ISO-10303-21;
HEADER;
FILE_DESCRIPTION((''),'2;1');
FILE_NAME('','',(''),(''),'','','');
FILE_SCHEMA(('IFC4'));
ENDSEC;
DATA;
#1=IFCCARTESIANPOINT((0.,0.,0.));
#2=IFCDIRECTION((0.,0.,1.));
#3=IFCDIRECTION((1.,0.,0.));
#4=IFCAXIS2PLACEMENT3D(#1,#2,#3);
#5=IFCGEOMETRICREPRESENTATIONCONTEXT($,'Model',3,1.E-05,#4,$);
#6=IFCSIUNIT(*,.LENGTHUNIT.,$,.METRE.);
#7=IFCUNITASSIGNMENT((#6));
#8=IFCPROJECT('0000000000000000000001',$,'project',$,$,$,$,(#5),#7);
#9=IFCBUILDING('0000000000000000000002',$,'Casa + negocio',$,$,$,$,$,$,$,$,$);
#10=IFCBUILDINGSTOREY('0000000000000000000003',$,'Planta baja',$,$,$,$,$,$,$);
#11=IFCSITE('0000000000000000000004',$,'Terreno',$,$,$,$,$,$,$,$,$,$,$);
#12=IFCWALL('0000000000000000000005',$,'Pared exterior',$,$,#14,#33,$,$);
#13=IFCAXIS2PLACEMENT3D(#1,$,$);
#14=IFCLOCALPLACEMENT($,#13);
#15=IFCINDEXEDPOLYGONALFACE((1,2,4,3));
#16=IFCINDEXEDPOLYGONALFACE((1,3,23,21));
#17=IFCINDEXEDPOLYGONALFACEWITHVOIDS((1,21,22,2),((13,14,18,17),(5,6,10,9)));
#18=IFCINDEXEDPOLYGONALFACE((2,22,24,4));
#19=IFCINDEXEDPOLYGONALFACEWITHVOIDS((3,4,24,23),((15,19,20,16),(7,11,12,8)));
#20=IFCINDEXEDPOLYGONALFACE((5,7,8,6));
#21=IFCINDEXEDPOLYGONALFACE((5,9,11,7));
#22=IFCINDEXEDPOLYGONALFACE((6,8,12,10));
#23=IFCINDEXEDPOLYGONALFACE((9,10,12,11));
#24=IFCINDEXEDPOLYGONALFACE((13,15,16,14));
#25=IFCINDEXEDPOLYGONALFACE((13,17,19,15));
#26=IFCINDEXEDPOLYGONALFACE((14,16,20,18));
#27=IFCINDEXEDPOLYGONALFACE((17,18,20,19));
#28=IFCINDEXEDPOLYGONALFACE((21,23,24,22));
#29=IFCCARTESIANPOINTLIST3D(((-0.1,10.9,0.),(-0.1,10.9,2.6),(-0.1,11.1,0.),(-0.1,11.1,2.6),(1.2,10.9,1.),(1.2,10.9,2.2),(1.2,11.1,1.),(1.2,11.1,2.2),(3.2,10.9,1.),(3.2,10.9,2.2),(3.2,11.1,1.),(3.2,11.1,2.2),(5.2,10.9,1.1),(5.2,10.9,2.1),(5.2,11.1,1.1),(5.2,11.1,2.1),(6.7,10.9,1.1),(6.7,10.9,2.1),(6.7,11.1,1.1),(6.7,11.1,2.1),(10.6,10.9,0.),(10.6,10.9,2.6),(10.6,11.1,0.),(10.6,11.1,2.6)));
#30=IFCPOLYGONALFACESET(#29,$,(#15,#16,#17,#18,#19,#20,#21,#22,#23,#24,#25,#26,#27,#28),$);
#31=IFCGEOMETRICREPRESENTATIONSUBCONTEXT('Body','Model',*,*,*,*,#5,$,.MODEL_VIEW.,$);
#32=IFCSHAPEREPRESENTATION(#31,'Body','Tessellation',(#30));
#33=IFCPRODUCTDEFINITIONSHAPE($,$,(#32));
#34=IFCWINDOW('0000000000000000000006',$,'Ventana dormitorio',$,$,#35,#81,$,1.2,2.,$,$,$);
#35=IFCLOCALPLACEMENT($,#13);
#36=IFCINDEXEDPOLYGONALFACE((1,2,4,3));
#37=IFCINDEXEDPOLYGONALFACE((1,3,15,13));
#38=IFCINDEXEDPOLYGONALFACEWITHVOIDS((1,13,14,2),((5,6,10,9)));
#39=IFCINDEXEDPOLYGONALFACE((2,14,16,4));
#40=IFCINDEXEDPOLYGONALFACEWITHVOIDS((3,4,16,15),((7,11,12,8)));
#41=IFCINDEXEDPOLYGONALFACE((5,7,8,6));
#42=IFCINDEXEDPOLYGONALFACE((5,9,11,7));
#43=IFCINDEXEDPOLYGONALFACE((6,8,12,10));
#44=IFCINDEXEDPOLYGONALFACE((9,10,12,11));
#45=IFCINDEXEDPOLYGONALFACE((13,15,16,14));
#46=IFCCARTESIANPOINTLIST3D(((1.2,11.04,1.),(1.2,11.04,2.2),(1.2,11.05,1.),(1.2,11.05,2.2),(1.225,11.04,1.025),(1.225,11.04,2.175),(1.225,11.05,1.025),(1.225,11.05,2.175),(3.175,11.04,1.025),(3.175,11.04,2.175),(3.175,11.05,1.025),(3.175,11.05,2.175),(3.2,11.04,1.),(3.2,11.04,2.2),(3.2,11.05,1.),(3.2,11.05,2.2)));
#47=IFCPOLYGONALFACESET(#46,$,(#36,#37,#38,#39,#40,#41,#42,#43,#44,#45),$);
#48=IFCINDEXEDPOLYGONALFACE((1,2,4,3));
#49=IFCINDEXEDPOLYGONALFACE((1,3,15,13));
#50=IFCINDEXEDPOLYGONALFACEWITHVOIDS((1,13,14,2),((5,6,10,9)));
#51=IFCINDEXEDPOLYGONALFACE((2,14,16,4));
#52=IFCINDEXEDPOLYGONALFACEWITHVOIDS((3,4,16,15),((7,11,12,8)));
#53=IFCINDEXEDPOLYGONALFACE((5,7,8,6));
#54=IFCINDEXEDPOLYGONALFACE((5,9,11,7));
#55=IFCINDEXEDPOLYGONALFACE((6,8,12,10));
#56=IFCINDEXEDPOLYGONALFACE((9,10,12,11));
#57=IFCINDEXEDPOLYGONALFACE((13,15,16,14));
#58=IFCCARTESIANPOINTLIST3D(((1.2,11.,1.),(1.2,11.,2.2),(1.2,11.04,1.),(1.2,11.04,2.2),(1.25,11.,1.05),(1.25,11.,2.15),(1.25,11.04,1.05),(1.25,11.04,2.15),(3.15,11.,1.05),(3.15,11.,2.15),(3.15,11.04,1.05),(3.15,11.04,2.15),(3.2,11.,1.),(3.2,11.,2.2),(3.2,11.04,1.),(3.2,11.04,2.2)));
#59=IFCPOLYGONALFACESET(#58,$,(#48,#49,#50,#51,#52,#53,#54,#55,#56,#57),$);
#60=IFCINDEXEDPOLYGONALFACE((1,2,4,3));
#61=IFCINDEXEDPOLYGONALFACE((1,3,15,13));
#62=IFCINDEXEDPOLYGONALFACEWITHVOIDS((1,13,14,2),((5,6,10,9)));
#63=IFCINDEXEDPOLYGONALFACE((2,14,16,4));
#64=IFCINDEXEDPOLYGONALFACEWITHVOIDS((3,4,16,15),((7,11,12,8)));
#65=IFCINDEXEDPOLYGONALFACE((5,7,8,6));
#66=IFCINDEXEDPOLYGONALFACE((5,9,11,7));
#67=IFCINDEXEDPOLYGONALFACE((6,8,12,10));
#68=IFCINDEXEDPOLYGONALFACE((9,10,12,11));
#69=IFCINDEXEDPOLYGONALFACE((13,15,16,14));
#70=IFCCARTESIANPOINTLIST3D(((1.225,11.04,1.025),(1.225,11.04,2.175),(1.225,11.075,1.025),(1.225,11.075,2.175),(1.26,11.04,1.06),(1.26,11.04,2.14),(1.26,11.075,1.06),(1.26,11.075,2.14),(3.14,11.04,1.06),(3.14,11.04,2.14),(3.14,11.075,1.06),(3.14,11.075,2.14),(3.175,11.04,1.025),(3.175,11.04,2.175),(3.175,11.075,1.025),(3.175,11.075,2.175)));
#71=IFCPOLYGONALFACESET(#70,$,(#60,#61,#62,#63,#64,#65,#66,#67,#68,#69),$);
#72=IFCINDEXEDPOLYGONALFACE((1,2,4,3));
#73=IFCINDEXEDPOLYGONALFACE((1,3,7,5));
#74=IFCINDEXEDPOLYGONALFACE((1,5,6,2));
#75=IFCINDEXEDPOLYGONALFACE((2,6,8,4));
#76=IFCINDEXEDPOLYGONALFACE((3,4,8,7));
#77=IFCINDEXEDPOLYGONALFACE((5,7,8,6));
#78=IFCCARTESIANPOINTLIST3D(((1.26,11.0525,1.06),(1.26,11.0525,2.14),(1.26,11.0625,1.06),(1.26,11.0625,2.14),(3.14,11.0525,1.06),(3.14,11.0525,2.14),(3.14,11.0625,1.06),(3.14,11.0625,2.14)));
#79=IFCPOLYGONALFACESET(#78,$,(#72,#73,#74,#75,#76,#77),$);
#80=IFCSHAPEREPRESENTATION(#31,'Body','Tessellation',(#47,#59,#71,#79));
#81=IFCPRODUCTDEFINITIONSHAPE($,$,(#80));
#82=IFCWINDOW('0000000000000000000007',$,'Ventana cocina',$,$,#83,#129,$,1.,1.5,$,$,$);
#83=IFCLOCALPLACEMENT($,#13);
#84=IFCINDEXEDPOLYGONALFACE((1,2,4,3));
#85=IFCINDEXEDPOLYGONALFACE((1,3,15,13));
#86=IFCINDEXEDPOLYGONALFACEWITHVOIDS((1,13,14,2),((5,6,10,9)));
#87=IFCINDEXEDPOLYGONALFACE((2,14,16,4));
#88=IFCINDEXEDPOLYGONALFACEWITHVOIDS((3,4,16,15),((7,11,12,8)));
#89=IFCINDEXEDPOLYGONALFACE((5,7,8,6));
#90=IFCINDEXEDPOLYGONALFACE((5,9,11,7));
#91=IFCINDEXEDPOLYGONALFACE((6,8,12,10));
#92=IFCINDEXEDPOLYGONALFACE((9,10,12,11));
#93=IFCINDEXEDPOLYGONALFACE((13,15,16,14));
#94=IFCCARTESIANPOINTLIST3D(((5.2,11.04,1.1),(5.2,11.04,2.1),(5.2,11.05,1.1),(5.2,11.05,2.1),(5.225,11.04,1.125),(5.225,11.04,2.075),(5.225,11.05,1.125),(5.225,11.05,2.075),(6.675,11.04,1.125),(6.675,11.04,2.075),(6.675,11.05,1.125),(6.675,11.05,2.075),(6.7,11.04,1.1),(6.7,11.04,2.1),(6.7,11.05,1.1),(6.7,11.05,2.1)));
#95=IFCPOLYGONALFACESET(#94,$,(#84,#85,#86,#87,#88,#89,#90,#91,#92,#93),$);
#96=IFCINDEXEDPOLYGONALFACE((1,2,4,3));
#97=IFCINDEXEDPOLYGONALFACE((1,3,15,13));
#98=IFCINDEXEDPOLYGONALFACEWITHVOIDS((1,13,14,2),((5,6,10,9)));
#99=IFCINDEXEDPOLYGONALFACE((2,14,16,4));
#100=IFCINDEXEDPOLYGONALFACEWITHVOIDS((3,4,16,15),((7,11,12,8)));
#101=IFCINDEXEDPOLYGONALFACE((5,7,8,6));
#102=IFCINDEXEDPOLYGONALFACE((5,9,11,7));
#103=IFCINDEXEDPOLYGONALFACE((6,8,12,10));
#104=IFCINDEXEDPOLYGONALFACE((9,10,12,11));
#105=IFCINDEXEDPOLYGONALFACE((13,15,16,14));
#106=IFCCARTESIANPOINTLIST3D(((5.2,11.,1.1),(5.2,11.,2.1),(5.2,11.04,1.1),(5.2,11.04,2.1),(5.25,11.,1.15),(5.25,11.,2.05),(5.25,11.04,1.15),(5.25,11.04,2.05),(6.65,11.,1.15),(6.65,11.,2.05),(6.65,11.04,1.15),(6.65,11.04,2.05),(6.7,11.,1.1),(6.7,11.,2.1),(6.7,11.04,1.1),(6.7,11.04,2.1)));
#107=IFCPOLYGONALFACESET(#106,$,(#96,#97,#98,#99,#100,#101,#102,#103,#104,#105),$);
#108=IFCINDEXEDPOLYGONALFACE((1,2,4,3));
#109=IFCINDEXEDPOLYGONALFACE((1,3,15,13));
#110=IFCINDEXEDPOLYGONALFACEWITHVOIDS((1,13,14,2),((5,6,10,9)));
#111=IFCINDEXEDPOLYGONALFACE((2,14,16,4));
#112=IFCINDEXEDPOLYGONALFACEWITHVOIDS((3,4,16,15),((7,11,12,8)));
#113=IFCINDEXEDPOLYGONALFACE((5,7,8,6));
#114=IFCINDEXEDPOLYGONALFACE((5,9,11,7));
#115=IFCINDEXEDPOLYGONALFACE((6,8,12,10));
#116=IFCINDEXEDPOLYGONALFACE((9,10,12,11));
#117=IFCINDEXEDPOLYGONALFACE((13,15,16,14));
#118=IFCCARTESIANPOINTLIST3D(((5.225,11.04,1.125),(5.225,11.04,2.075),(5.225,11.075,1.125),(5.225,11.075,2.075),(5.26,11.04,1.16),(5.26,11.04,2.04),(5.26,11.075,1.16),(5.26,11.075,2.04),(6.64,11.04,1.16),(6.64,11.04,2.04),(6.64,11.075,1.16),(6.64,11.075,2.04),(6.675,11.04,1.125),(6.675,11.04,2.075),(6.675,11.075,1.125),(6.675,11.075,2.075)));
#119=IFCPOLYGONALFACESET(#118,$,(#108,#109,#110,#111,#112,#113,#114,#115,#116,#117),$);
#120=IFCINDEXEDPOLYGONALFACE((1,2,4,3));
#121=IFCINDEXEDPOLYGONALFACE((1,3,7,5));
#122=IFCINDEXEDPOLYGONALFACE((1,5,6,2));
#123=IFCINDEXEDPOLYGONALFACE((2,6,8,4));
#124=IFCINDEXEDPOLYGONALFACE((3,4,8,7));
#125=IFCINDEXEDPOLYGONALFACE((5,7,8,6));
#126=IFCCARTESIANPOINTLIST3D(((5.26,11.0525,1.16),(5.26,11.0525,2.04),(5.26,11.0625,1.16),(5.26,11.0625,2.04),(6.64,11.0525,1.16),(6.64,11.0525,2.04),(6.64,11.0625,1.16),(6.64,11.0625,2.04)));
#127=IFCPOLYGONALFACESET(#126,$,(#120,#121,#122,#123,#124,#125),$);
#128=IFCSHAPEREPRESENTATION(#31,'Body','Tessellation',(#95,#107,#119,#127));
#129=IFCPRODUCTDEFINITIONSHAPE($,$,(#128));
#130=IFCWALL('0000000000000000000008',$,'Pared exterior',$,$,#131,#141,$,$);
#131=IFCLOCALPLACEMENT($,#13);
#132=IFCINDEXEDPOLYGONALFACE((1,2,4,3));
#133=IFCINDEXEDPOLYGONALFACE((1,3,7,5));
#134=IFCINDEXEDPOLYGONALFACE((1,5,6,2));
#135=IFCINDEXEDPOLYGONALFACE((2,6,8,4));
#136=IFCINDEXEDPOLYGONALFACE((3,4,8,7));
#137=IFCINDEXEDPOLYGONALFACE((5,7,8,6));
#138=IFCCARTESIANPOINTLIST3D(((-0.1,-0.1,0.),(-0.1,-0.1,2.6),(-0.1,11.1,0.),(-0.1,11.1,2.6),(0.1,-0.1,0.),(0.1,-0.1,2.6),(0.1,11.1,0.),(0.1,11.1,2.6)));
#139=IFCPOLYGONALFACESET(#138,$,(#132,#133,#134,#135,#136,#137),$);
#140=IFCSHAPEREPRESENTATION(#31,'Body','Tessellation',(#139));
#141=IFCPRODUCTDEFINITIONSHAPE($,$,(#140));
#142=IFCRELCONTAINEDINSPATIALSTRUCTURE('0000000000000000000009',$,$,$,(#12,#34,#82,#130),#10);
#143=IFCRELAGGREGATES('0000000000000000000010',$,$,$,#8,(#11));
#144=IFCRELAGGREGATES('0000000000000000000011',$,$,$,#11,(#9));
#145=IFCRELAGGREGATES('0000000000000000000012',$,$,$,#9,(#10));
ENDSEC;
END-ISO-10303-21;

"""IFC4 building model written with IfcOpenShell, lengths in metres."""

from ifc_helpers import new_model, si_unit, frame, origin_with_axes, place, context, subcontext, project, spatial, line, indexed_curve, outline, extrude, element, fill, save


model = new_model("IFC4")

# Units and contexts
model_context = context("Model", 3, precision=1e-05, world=origin_with_axes())
body_context = subcontext(model_context, "Body", "Model", "MODEL_VIEW")
ifc_project = project(units=[si_unit("LENGTHUNIT", "METRE")], contexts=[model_context])

# Site, building, storey
site = spatial("IfcSite", under=ifc_project, Name="Terreno")
building = spatial("IfcBuilding", under=site, Name="Casa + negocio")
storey = spatial("IfcBuildingStorey", under=building, Name="Planta baja")

# Wall, openings, windows
wall_1_placement = place(None, frame((-0.1, 11.0, 0.0), z_axis=(0.0, 0.0, 1.0), x_axis=(1.0, 0.0, 0.0)))
wall_1 = element("IfcWall", 1, at=wall_1_placement, inside=storey, Name="Pared exterior", context=body_context, shape_type="SweptSolid", body=[
    extrude(outline(indexed_curve([(0.0, 0.0), (0.0, 0.2), (10.7, 0.2), (10.7, 0.0), (0.0, 0.0)], self_intersect=False)), frame((0.0, -0.1, 0.0), z_axis=(0.0, 0.0, 1.0), x_axis=(1.0, 0.0, 0.0)), (0.0, 0.0, 1.0), 2.6),
])
opening_1_placement = place(wall_1_placement, frame((1.3, 0.0, 1.0), z_axis=(0.0, 0.0, 1.0), x_axis=(1.0, 0.0, 0.0)))
opening_1 = element("IfcOpeningElement", 2, at=opening_1_placement, cuts=wall_1, context=body_context, shape_type="SweptSolid", body=[
    extrude(outline(indexed_curve([(0.0, 0.0), (0.0, 0.3), (2.0, 0.3), (2.0, 0.0), (0.0, 0.0)], self_intersect=False)), frame((0.0, -0.15, 0.0), z_axis=(0.0, 0.0, 1.0), x_axis=(1.0, 0.0, 0.0)), (0.0, 0.0, 1.0), 1.2),
])
opening_2_placement = place(wall_1_placement, frame((5.3, 0.0, 1.1), z_axis=(0.0, 0.0, 1.0), x_axis=(1.0, 0.0, 0.0)))
opening_2 = element("IfcOpeningElement", 3, at=opening_2_placement, cuts=wall_1, context=body_context, shape_type="SweptSolid", body=[
    extrude(outline(indexed_curve([(0.0, 0.0), (0.0, 0.3), (1.5, 0.3), (1.5, 0.0), (0.0, 0.0)], self_intersect=False)), frame((0.0, -0.15, 0.0), z_axis=(0.0, 0.0, 1.0), x_axis=(1.0, 0.0, 0.0)), (0.0, 0.0, 1.0), 1.0),
])
window_1_placement = place(opening_1_placement, frame((0.0, -0.05, 0.0), z_axis=(0.0, 0.0, 1.0), x_axis=(1.0, 0.0, 0.0)))
window_1 = element("IfcWindow", 4, at=window_1_placement, inside=storey, Name="Ventana dormitorio", OverallHeight=1.2, OverallWidth=2.0, context=body_context, shape_type="SweptSolid", body=[
    extrude(outline(indexed_curve([(0.0, 0.0), (2.0, 0.0), (2.0, 1.2), (0.0, 1.2)], segments=[line(1, 2, 3, 4, 1)]), holes=[indexed_curve([(0.025, 0.025), (1.975, 0.025), (1.975, 1.175), (0.025, 1.175)], segments=[line(1, 2, 3, 4, 1)])]), frame((0.0, 0.09, 0.0), z_axis=(0.0, -1.0, 0.0), x_axis=(1.0, 0.0, 0.0)), (0.0, 0.0, -1.0), 0.01),
    extrude(outline(indexed_curve([(0.0, 0.0), (2.0, 0.0), (2.0, 1.2), (0.0, 1.2)], segments=[line(1, 2, 3, 4, 1)]), holes=[indexed_curve([(0.05, 0.05), (1.95, 0.05), (1.95, 1.15), (0.05, 1.15)], segments=[line(1, 2, 3, 4, 1)])]), frame((0.0, 0.05, 0.0), z_axis=(0.0, -1.0, 0.0), x_axis=(1.0, 0.0, 0.0)), (0.0, 0.0, -1.0), 0.04),
    extrude(outline(indexed_curve([(0.0, 0.0), (1.95, 0.0), (1.95, 1.15), (0.0, 1.15)], segments=[line(1, 2, 3, 4, 1)]), holes=[indexed_curve([(0.035, 0.035), (1.915, 0.035), (1.915, 1.115), (0.035, 1.115)], segments=[line(1, 2, 3, 4, 1)])]), frame((0.025, 0.09, 0.025), z_axis=(0.0, -1.0, 0.0), x_axis=(1.0, 0.0, 0.0)), (0.0, 0.0, -1.0), 0.035),
    extrude(outline(indexed_curve([(0.035, 0.035), (1.915, 0.035), (1.915, 1.115), (0.035, 1.115)], segments=[line(1, 2, 3, 4, 1)])), frame((0.025, 0.1025, 0.025), z_axis=(0.0, -1.0, 0.0), x_axis=(1.0, 0.0, 0.0)), (0.0, 0.0, -1.0), 0.01),
])
fill(opening_1, window_1)
window_2_placement = place(opening_2_placement, frame((0.0, -0.05, 0.0), z_axis=(0.0, 0.0, 1.0), x_axis=(1.0, 0.0, 0.0)))
window_2 = element("IfcWindow", 5, at=window_2_placement, inside=storey, Name="Ventana cocina", OverallHeight=1.0, OverallWidth=1.5, context=body_context, shape_type="SweptSolid", body=[
    extrude(outline(indexed_curve([(0.0, 0.0), (1.5, 0.0), (1.5, 1.0), (0.0, 1.0)], segments=[line(1, 2, 3, 4, 1)]), holes=[indexed_curve([(0.025, 0.025), (1.475, 0.025), (1.475, 0.975), (0.025, 0.975)], segments=[line(1, 2, 3, 4, 1)])]), frame((0.0, 0.09, 0.0), z_axis=(0.0, -1.0, 0.0), x_axis=(1.0, 0.0, 0.0)), (0.0, 0.0, -1.0), 0.01),
    extrude(outline(indexed_curve([(0.0, 0.0), (1.5, 0.0), (1.5, 1.0), (0.0, 1.0)], segments=[line(1, 2, 3, 4, 1)]), holes=[indexed_curve([(0.05, 0.05), (1.45, 0.05), (1.45, 0.95), (0.05, 0.95)], segments=[line(1, 2, 3, 4, 1)])]), frame((0.0, 0.05, 0.0), z_axis=(0.0, -1.0, 0.0), x_axis=(1.0, 0.0, 0.0)), (0.0, 0.0, -1.0), 0.04),
    extrude(outline(indexed_curve([(0.0, 0.0), (1.45, 0.0), (1.45, 0.95), (0.0, 0.95)], segments=[line(1, 2, 3, 4, 1)]), holes=[indexed_curve([(0.035, 0.035), (1.415, 0.035), (1.415, 0.915), (0.035, 0.915)], segments=[line(1, 2, 3, 4, 1)])]), frame((0.025, 0.09, 0.025), z_axis=(0.0, -1.0, 0.0), x_axis=(1.0, 0.0, 0.0)), (0.0, 0.0, -1.0), 0.035),
    extrude(outline(indexed_curve([(0.035, 0.035), (1.415, 0.035), (1.415, 0.915), (0.035, 0.915)], segments=[line(1, 2, 3, 4, 1)])), frame((0.025, 0.1025, 0.025), z_axis=(0.0, -1.0, 0.0), x_axis=(1.0, 0.0, 0.0)), (0.0, 0.0, -1.0), 0.01),
])
fill(opening_2, window_2)

# Wall
wall_2_placement = place(None, frame((0.0, 11.1, 0.0), z_axis=(0.0, 0.0, 1.0), x_axis=(0.0, -1.0, 0.0)))
element("IfcWall", 6, at=wall_2_placement, inside=storey, Name="Pared exterior", context=body_context, shape_type="SweptSolid", body=[
    extrude(outline(indexed_curve([(0.0, 0.0), (0.0, 0.2), (11.2, 0.2), (11.2, 0.0), (0.0, 0.0)], self_intersect=False)), frame((0.0, -0.1, 0.0), z_axis=(0.0, 0.0, 1.0), x_axis=(1.0, 0.0, 0.0)), (0.0, 0.0, 1.0), 2.6),
])

save(model, "model.ifc")
